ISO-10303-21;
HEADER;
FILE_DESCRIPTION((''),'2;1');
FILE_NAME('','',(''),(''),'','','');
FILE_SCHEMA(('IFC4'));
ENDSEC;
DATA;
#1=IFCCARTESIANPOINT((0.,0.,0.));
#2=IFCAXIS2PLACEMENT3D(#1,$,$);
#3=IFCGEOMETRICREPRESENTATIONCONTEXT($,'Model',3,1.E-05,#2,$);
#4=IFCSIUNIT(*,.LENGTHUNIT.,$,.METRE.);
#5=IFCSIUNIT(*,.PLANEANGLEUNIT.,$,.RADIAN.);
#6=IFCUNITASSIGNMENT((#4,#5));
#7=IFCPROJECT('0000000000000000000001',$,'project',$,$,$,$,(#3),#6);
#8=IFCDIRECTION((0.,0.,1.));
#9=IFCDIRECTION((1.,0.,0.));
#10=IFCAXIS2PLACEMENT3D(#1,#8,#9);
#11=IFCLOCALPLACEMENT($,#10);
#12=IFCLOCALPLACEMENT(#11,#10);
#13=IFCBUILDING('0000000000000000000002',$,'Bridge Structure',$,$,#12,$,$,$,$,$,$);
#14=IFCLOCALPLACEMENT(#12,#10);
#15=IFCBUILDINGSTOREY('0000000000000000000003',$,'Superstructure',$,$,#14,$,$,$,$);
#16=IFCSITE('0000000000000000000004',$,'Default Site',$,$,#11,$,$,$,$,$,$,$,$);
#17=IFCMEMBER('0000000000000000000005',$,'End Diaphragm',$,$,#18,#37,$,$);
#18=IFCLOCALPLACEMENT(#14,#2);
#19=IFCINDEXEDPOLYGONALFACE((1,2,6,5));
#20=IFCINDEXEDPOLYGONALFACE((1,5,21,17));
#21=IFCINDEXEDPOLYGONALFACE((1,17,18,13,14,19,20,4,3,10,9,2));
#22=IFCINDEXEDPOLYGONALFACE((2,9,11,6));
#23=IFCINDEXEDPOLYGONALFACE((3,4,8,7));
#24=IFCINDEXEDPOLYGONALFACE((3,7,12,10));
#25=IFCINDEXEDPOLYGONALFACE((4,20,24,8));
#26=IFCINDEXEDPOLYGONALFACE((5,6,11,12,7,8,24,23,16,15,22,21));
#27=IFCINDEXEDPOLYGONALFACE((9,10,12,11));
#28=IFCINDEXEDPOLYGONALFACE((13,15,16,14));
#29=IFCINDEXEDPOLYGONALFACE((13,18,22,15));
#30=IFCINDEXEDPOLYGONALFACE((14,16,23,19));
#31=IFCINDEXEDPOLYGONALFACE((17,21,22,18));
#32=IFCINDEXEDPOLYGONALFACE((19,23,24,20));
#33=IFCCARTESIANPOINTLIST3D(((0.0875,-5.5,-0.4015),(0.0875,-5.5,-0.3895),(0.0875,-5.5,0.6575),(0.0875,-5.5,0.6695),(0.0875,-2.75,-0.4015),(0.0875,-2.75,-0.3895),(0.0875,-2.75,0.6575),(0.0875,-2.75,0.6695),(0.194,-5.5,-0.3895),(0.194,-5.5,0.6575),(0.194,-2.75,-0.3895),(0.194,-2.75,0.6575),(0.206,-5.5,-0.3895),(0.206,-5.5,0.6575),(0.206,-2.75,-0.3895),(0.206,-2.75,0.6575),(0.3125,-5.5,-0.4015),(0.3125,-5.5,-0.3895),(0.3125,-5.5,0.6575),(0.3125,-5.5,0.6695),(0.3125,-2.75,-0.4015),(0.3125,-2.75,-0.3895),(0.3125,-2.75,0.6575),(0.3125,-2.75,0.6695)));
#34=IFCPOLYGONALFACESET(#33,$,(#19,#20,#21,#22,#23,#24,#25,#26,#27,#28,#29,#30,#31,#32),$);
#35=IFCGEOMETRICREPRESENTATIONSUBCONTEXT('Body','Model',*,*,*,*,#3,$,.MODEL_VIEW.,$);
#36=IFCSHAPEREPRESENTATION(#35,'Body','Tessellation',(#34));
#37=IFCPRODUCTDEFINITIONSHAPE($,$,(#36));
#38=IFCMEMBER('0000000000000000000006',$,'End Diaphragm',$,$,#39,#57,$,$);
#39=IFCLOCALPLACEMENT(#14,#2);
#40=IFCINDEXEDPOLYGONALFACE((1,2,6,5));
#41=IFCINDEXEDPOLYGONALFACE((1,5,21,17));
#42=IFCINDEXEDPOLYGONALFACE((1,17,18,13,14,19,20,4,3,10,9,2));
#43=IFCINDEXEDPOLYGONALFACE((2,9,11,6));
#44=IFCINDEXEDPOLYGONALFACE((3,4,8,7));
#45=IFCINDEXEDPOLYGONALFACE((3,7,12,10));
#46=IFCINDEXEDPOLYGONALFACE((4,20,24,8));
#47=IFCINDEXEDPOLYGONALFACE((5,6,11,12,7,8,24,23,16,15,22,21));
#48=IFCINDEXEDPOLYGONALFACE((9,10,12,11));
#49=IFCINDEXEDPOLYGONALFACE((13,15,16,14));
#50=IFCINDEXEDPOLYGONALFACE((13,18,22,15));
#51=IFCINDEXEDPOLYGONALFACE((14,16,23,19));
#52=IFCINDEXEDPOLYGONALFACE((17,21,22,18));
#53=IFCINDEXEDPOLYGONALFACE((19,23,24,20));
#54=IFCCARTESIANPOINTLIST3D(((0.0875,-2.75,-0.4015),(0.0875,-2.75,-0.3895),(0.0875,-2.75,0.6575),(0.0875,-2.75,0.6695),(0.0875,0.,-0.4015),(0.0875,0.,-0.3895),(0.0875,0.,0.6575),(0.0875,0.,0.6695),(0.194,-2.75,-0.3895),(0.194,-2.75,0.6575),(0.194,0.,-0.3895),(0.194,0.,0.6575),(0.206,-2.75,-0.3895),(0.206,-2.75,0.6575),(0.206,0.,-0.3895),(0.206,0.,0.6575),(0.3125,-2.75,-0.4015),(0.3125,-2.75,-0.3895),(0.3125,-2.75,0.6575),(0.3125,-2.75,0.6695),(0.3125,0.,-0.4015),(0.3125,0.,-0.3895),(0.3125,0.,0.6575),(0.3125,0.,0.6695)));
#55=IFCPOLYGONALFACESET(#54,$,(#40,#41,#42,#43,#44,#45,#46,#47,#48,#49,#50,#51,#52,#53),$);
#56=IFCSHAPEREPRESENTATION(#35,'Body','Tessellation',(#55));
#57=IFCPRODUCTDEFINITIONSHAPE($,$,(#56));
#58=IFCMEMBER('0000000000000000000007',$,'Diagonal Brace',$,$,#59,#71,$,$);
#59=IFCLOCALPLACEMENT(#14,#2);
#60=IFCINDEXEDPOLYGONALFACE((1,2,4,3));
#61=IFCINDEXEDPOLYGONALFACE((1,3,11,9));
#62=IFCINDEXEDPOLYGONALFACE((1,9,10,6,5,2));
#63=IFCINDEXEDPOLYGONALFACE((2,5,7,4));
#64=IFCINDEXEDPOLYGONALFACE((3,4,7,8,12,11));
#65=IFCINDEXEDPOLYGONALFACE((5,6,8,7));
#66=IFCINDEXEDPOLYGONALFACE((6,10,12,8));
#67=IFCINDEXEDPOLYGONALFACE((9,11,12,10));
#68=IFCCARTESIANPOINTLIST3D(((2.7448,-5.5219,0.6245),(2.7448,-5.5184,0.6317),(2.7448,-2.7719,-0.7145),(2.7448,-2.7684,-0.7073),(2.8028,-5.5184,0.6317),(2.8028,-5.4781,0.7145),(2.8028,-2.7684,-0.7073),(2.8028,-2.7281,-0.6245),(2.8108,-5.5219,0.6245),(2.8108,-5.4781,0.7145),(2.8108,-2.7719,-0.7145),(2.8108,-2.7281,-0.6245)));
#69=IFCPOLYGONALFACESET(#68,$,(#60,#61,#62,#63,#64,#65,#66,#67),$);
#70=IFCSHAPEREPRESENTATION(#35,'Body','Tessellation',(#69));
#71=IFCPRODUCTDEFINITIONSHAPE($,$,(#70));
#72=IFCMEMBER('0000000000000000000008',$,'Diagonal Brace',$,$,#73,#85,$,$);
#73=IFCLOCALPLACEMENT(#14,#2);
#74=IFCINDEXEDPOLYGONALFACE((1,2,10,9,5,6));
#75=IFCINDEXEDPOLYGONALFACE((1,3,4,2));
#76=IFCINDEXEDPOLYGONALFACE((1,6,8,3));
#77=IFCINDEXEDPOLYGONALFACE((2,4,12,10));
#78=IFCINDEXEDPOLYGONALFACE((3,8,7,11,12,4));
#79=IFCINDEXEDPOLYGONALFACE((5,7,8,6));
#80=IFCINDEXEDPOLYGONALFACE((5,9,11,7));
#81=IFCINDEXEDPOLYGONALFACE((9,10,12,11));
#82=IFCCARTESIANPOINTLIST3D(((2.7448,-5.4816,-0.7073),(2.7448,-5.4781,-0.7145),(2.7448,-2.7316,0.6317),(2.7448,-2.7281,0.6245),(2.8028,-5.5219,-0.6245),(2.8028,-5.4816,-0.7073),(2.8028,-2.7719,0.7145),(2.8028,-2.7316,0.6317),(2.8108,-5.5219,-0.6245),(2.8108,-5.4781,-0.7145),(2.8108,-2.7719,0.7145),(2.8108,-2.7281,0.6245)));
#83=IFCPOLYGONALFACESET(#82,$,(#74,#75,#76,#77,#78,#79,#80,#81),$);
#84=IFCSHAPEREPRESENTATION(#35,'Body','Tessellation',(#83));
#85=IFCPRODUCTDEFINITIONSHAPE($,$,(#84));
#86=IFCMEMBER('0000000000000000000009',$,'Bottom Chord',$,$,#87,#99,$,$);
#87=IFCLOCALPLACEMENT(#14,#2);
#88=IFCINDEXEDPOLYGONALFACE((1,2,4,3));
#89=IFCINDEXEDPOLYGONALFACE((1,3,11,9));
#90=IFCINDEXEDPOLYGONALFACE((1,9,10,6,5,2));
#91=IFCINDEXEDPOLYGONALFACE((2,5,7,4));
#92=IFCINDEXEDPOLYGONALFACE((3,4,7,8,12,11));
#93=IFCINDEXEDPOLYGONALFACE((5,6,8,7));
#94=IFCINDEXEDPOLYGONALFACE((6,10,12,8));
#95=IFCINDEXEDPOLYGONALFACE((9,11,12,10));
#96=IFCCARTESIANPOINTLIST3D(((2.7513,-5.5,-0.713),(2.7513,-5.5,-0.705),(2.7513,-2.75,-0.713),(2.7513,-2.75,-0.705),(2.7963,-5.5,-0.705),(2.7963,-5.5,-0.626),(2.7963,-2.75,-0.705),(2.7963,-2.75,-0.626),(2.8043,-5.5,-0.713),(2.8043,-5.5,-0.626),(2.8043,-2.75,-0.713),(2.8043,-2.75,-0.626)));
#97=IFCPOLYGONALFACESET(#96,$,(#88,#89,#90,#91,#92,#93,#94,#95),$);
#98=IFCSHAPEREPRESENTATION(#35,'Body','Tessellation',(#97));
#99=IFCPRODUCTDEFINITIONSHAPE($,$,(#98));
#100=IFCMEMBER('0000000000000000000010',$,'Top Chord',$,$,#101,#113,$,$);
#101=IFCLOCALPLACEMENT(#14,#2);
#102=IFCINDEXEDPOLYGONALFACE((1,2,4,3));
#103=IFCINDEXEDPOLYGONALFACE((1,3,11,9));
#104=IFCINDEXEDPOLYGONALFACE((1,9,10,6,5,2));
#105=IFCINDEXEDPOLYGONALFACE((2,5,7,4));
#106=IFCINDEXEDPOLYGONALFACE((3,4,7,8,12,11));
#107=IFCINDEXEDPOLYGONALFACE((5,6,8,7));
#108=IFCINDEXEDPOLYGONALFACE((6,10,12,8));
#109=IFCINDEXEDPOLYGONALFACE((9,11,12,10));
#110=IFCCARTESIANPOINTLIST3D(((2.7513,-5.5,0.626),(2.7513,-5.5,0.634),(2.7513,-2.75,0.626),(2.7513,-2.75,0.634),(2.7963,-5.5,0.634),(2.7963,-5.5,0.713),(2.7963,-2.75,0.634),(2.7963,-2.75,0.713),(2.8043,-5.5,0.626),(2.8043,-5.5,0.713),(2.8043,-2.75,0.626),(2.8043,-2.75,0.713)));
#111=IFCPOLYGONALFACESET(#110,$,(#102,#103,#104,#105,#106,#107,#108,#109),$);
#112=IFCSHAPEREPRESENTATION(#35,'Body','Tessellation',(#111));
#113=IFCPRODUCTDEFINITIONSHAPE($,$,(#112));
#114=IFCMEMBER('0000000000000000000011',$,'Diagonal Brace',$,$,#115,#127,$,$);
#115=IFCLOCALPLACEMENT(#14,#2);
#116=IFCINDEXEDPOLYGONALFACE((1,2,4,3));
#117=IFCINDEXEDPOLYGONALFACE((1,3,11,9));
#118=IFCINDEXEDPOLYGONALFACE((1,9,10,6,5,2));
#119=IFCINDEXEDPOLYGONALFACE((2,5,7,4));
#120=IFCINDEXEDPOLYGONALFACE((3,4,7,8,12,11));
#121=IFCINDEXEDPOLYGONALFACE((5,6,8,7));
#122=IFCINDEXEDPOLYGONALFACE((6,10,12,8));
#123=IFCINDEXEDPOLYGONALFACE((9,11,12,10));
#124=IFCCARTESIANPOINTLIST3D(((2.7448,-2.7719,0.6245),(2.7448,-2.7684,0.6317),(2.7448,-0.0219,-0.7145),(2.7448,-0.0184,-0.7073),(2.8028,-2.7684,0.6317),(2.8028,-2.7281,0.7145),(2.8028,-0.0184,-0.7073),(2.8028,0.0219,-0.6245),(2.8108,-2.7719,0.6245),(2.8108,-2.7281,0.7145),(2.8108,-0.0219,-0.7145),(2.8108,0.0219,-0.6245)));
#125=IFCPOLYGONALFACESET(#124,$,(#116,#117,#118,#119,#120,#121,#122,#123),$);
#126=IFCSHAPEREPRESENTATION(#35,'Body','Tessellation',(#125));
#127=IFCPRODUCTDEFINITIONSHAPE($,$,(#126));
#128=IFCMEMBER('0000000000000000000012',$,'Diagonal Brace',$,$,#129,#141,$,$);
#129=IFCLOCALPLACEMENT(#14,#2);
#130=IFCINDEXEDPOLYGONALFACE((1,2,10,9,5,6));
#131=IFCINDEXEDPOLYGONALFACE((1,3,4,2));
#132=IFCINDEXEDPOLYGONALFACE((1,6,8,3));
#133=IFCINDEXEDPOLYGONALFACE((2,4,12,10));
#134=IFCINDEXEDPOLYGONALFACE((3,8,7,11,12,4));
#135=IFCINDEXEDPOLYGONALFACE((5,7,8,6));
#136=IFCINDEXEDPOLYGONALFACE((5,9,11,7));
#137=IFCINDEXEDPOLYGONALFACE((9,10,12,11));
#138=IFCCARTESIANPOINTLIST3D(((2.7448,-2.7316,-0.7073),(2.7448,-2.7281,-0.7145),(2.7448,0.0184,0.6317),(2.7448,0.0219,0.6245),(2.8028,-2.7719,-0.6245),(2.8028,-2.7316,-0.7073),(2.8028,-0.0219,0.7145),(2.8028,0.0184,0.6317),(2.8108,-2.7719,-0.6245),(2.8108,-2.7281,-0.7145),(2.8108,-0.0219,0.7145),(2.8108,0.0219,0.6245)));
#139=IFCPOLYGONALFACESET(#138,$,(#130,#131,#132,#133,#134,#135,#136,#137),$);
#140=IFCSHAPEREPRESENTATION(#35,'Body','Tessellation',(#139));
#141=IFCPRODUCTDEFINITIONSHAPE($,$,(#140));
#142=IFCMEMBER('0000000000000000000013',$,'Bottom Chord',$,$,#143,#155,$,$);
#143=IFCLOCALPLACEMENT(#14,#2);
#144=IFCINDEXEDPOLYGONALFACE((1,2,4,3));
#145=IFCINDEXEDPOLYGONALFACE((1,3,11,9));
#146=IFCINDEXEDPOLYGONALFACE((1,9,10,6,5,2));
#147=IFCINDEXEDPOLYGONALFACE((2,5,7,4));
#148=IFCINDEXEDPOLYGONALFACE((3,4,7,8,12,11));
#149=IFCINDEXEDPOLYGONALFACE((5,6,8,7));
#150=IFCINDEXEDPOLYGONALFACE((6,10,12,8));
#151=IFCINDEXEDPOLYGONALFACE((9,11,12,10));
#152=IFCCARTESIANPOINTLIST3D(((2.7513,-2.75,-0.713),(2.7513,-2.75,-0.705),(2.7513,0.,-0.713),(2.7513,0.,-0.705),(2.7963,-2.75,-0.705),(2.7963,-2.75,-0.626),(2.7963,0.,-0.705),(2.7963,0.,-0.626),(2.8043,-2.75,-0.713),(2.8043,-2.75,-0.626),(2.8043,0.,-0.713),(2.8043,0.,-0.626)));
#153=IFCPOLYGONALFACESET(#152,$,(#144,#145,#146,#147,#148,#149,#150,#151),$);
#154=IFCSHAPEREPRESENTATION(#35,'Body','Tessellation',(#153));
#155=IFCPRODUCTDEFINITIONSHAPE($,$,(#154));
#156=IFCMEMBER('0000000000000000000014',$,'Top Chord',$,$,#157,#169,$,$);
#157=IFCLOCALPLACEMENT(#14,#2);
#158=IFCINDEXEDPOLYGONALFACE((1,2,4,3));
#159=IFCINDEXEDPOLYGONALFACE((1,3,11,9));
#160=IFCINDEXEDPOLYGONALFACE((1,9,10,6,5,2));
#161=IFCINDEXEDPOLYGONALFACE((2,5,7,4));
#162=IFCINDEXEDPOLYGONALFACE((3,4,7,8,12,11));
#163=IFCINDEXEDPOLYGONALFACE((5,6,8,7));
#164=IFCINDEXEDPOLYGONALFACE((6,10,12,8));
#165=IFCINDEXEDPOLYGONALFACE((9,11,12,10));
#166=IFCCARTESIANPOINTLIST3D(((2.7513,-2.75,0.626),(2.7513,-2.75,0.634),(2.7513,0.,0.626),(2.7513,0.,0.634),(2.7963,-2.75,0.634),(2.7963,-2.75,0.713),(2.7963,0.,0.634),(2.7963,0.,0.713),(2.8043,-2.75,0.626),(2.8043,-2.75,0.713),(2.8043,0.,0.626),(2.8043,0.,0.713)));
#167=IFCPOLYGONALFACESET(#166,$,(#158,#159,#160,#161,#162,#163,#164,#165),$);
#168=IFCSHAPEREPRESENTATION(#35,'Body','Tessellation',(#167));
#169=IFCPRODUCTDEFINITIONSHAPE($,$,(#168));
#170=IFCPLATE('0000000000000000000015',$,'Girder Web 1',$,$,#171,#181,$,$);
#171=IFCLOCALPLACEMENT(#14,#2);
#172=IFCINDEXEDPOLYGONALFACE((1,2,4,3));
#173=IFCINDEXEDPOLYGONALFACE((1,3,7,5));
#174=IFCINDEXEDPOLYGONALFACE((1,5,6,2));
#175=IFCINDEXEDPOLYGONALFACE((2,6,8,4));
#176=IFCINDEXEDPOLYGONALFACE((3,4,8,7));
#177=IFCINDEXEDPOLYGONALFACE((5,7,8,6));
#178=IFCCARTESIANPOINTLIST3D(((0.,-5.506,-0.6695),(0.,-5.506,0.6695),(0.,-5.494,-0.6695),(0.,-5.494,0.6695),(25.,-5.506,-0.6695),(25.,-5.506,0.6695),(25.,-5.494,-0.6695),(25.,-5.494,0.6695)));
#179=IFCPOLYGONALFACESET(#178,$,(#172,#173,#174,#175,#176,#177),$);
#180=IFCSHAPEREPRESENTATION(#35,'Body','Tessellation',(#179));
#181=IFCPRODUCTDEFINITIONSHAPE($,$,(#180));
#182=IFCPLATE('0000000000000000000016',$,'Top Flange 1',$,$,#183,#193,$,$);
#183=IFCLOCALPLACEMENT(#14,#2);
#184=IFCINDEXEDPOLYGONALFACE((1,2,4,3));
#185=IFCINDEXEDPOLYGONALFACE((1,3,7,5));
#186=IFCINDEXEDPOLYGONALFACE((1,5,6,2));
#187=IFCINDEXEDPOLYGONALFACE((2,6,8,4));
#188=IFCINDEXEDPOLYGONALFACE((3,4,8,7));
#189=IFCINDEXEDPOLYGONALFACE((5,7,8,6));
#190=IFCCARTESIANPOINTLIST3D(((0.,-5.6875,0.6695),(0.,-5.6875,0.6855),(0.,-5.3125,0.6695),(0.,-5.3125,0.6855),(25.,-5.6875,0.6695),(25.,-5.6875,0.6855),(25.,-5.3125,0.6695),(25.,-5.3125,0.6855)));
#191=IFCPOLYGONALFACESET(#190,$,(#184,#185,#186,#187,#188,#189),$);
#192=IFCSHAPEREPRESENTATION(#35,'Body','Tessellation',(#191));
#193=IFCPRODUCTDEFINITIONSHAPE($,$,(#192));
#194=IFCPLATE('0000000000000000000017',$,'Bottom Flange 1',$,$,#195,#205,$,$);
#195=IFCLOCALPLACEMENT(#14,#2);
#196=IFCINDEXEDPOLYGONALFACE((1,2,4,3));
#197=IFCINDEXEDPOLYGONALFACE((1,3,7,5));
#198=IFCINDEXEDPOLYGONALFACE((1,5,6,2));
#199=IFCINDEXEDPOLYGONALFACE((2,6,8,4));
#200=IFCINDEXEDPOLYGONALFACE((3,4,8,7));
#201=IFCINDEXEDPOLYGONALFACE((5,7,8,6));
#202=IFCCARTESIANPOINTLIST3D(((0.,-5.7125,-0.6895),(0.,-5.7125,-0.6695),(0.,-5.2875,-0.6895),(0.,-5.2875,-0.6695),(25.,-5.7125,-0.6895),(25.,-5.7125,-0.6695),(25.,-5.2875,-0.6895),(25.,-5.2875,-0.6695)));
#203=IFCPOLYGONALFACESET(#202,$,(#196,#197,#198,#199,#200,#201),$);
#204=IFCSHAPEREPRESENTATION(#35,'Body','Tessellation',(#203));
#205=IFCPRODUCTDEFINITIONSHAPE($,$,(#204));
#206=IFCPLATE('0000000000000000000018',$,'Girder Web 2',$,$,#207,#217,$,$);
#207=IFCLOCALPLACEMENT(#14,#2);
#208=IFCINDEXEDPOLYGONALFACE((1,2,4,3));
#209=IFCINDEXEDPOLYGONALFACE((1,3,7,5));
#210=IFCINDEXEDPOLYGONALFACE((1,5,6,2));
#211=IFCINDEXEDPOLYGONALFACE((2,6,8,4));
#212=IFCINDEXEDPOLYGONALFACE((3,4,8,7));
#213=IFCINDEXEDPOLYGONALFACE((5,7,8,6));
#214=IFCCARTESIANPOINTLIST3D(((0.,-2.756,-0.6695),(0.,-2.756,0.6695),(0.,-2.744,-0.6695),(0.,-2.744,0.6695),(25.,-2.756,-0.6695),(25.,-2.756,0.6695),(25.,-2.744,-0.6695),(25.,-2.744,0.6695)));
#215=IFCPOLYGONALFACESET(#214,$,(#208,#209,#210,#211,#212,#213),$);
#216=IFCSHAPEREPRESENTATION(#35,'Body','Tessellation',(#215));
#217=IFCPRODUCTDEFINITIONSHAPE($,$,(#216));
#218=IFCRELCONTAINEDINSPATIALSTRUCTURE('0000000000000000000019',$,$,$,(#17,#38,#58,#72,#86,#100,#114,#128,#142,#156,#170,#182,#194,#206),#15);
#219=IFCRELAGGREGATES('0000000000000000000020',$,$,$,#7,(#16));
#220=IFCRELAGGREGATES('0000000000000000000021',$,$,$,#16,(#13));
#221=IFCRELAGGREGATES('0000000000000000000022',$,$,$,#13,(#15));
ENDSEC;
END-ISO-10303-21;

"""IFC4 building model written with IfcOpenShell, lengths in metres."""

from ifc_helpers import new_model, si_unit, frame, origin, origin_with_axes, origin_2d_with_axis, place, context, subcontext, project, spatial, rectangle, i_section, l_section, extrude, element, save


model = new_model("IFC4")

# Units and contexts
model_context = context("Model", 3, precision=1e-05, world=origin())
body_context = subcontext(model_context, "Body", "Model", "MODEL_VIEW")
ifc_project = project(units=[si_unit("LENGTHUNIT", "METRE"), si_unit("PLANEANGLEUNIT", "RADIAN")], contexts=[model_context])

# Site, building, storey
site_placement = place(None, origin_with_axes())
site = spatial("IfcSite", under=ifc_project, at=site_placement, Name="Default Site")
building_placement = place(site_placement, origin_with_axes())
building = spatial("IfcBuilding", under=site, at=building_placement, Name="Bridge Structure")
storey_placement = place(building_placement, origin_with_axes())
storey = spatial("IfcBuildingStorey", under=building, at=storey_placement, Name="Superstructure")

# Members
for number, where, z_axis, x_axis, name in (
    (1, (0.2, -5.5, 0.134), (0.0, 1.0, 0.0), (-1.0, 0.0, 0.0), "End Diaphragm"),
    (2, (0.2, -2.75, 0.134), (0.0, 1.0, 0.0), (-1.0, 0.0, 0.0), "End Diaphragm"),
):
    element("IfcMember", number, at=place(storey_placement, frame(where, z_axis=z_axis, x_axis=x_axis)), inside=storey, Name=name, context=body_context, shape_type="SweptSolid", body=[
        extrude(i_section(OverallWidth=0.225, OverallDepth=1.071, WebThickness=0.012, FlangeThickness=0.012, at=origin_2d_with_axis()), origin_with_axes(), (0.0, 0.0, 1.0), 2.75),
    ])
for number, where, z_axis, x_axis, name in (
    (3, (2.7778, -5.5, 0.6695), (0.0, 0.899086, -0.437773), (-1.0, 0.0, 0.0), "Diagonal Brace"),
    (4, (2.7778, -5.5, -0.6695), (0.0, 0.899086, 0.437773), (-1.0, 0.0, 0.0), "Diagonal Brace"),
):
    element("IfcMember", number, at=place(storey_placement, frame(where, z_axis=z_axis, x_axis=x_axis)), inside=storey, Name=name, context=body_context, shape_type="SweptSolid", body=[
        extrude(l_section(Depth=0.1, Width=0.066, Thickness=0.008, at=origin_2d_with_axis()), origin_with_axes(), (0.0, 0.0, 1.0), 3.0587),
    ])
for number, where, z_axis, x_axis, name in (
    (5, (2.7778, -5.5, -0.6695), (0.0, 1.0, 0.0), (-1.0, 0.0, 0.0), "Bottom Chord"),
    (6, (2.7778, -5.5, 0.6695), (0.0, 1.0, 0.0), (-1.0, 0.0, 0.0), "Top Chord"),
):
    element("IfcMember", number, at=place(storey_placement, frame(where, z_axis=z_axis, x_axis=x_axis)), inside=storey, Name=name, context=body_context, shape_type="SweptSolid", body=[
        extrude(l_section(Depth=0.087, Width=0.053, Thickness=0.008, at=origin_2d_with_axis()), origin_with_axes(), (0.0, 0.0, 1.0), 2.75),
    ])
for number, where, z_axis, x_axis, name in (
    (7, (2.7778, -2.75, 0.6695), (0.0, 0.899086, -0.437773), (-1.0, 0.0, 0.0), "Diagonal Brace"),
    (8, (2.7778, -2.75, -0.6695), (0.0, 0.899086, 0.437773), (-1.0, 0.0, 0.0), "Diagonal Brace"),
):
    element("IfcMember", number, at=place(storey_placement, frame(where, z_axis=z_axis, x_axis=x_axis)), inside=storey, Name=name, context=body_context, shape_type="SweptSolid", body=[
        extrude(l_section(Depth=0.1, Width=0.066, Thickness=0.008, at=origin_2d_with_axis()), origin_with_axes(), (0.0, 0.0, 1.0), 3.0587),
    ])
for number, where, z_axis, x_axis, name in (
    (9, (2.7778, -2.75, -0.6695), (0.0, 1.0, 0.0), (-1.0, 0.0, 0.0), "Bottom Chord"),
    (10, (2.7778, -2.75, 0.6695), (0.0, 1.0, 0.0), (-1.0, 0.0, 0.0), "Top Chord"),
):
    element("IfcMember", number, at=place(storey_placement, frame(where, z_axis=z_axis, x_axis=x_axis)), inside=storey, Name=name, context=body_context, shape_type="SweptSolid", body=[
        extrude(l_section(Depth=0.087, Width=0.053, Thickness=0.008, at=origin_2d_with_axis()), origin_with_axes(), (0.0, 0.0, 1.0), 2.75),
    ])

# Plates
plate_1_placement = place(storey_placement, frame((0.0, -5.5, 0.0), z_axis=(1.0, 0.0, 0.0), x_axis=(0.0, 1.0, 0.0)))
element("IfcPlate", 11, at=plate_1_placement, inside=storey, Name="Girder Web 1", context=body_context, shape_type="SweptSolid", body=[
    extrude(rectangle(XDim=0.012, YDim=1.339, at=origin_2d_with_axis()), origin_with_axes(), (0.0, 0.0, 1.0), 25.0),
])
plate_2_placement = place(storey_placement, frame((0.0, -5.5, 0.6775), z_axis=(1.0, 0.0, 0.0), x_axis=(0.0, 1.0, 0.0)))
element("IfcPlate", 12, at=plate_2_placement, inside=storey, Name="Top Flange 1", context=body_context, shape_type="SweptSolid", body=[
    extrude(rectangle(XDim=0.375, YDim=0.016, at=origin_2d_with_axis()), origin_with_axes(), (0.0, 0.0, 1.0), 25.0),
])
plate_3_placement = place(storey_placement, frame((0.0, -5.5, -0.6795), z_axis=(1.0, 0.0, 0.0), x_axis=(0.0, 1.0, 0.0)))
element("IfcPlate", 13, at=plate_3_placement, inside=storey, Name="Bottom Flange 1", context=body_context, shape_type="SweptSolid", body=[
    extrude(rectangle(XDim=0.425, YDim=0.02, at=origin_2d_with_axis()), origin_with_axes(), (0.0, 0.0, 1.0), 25.0),
])
plate_4_placement = place(storey_placement, frame((0.0, -2.75, 0.0), z_axis=(1.0, 0.0, 0.0), x_axis=(0.0, 1.0, 0.0)))
element("IfcPlate", 14, at=plate_4_placement, inside=storey, Name="Girder Web 2", context=body_context, shape_type="SweptSolid", body=[
    extrude(rectangle(XDim=0.012, YDim=1.339, at=origin_2d_with_axis()), origin_with_axes(), (0.0, 0.0, 1.0), 25.0),
])

save(model, "model.ifc")
